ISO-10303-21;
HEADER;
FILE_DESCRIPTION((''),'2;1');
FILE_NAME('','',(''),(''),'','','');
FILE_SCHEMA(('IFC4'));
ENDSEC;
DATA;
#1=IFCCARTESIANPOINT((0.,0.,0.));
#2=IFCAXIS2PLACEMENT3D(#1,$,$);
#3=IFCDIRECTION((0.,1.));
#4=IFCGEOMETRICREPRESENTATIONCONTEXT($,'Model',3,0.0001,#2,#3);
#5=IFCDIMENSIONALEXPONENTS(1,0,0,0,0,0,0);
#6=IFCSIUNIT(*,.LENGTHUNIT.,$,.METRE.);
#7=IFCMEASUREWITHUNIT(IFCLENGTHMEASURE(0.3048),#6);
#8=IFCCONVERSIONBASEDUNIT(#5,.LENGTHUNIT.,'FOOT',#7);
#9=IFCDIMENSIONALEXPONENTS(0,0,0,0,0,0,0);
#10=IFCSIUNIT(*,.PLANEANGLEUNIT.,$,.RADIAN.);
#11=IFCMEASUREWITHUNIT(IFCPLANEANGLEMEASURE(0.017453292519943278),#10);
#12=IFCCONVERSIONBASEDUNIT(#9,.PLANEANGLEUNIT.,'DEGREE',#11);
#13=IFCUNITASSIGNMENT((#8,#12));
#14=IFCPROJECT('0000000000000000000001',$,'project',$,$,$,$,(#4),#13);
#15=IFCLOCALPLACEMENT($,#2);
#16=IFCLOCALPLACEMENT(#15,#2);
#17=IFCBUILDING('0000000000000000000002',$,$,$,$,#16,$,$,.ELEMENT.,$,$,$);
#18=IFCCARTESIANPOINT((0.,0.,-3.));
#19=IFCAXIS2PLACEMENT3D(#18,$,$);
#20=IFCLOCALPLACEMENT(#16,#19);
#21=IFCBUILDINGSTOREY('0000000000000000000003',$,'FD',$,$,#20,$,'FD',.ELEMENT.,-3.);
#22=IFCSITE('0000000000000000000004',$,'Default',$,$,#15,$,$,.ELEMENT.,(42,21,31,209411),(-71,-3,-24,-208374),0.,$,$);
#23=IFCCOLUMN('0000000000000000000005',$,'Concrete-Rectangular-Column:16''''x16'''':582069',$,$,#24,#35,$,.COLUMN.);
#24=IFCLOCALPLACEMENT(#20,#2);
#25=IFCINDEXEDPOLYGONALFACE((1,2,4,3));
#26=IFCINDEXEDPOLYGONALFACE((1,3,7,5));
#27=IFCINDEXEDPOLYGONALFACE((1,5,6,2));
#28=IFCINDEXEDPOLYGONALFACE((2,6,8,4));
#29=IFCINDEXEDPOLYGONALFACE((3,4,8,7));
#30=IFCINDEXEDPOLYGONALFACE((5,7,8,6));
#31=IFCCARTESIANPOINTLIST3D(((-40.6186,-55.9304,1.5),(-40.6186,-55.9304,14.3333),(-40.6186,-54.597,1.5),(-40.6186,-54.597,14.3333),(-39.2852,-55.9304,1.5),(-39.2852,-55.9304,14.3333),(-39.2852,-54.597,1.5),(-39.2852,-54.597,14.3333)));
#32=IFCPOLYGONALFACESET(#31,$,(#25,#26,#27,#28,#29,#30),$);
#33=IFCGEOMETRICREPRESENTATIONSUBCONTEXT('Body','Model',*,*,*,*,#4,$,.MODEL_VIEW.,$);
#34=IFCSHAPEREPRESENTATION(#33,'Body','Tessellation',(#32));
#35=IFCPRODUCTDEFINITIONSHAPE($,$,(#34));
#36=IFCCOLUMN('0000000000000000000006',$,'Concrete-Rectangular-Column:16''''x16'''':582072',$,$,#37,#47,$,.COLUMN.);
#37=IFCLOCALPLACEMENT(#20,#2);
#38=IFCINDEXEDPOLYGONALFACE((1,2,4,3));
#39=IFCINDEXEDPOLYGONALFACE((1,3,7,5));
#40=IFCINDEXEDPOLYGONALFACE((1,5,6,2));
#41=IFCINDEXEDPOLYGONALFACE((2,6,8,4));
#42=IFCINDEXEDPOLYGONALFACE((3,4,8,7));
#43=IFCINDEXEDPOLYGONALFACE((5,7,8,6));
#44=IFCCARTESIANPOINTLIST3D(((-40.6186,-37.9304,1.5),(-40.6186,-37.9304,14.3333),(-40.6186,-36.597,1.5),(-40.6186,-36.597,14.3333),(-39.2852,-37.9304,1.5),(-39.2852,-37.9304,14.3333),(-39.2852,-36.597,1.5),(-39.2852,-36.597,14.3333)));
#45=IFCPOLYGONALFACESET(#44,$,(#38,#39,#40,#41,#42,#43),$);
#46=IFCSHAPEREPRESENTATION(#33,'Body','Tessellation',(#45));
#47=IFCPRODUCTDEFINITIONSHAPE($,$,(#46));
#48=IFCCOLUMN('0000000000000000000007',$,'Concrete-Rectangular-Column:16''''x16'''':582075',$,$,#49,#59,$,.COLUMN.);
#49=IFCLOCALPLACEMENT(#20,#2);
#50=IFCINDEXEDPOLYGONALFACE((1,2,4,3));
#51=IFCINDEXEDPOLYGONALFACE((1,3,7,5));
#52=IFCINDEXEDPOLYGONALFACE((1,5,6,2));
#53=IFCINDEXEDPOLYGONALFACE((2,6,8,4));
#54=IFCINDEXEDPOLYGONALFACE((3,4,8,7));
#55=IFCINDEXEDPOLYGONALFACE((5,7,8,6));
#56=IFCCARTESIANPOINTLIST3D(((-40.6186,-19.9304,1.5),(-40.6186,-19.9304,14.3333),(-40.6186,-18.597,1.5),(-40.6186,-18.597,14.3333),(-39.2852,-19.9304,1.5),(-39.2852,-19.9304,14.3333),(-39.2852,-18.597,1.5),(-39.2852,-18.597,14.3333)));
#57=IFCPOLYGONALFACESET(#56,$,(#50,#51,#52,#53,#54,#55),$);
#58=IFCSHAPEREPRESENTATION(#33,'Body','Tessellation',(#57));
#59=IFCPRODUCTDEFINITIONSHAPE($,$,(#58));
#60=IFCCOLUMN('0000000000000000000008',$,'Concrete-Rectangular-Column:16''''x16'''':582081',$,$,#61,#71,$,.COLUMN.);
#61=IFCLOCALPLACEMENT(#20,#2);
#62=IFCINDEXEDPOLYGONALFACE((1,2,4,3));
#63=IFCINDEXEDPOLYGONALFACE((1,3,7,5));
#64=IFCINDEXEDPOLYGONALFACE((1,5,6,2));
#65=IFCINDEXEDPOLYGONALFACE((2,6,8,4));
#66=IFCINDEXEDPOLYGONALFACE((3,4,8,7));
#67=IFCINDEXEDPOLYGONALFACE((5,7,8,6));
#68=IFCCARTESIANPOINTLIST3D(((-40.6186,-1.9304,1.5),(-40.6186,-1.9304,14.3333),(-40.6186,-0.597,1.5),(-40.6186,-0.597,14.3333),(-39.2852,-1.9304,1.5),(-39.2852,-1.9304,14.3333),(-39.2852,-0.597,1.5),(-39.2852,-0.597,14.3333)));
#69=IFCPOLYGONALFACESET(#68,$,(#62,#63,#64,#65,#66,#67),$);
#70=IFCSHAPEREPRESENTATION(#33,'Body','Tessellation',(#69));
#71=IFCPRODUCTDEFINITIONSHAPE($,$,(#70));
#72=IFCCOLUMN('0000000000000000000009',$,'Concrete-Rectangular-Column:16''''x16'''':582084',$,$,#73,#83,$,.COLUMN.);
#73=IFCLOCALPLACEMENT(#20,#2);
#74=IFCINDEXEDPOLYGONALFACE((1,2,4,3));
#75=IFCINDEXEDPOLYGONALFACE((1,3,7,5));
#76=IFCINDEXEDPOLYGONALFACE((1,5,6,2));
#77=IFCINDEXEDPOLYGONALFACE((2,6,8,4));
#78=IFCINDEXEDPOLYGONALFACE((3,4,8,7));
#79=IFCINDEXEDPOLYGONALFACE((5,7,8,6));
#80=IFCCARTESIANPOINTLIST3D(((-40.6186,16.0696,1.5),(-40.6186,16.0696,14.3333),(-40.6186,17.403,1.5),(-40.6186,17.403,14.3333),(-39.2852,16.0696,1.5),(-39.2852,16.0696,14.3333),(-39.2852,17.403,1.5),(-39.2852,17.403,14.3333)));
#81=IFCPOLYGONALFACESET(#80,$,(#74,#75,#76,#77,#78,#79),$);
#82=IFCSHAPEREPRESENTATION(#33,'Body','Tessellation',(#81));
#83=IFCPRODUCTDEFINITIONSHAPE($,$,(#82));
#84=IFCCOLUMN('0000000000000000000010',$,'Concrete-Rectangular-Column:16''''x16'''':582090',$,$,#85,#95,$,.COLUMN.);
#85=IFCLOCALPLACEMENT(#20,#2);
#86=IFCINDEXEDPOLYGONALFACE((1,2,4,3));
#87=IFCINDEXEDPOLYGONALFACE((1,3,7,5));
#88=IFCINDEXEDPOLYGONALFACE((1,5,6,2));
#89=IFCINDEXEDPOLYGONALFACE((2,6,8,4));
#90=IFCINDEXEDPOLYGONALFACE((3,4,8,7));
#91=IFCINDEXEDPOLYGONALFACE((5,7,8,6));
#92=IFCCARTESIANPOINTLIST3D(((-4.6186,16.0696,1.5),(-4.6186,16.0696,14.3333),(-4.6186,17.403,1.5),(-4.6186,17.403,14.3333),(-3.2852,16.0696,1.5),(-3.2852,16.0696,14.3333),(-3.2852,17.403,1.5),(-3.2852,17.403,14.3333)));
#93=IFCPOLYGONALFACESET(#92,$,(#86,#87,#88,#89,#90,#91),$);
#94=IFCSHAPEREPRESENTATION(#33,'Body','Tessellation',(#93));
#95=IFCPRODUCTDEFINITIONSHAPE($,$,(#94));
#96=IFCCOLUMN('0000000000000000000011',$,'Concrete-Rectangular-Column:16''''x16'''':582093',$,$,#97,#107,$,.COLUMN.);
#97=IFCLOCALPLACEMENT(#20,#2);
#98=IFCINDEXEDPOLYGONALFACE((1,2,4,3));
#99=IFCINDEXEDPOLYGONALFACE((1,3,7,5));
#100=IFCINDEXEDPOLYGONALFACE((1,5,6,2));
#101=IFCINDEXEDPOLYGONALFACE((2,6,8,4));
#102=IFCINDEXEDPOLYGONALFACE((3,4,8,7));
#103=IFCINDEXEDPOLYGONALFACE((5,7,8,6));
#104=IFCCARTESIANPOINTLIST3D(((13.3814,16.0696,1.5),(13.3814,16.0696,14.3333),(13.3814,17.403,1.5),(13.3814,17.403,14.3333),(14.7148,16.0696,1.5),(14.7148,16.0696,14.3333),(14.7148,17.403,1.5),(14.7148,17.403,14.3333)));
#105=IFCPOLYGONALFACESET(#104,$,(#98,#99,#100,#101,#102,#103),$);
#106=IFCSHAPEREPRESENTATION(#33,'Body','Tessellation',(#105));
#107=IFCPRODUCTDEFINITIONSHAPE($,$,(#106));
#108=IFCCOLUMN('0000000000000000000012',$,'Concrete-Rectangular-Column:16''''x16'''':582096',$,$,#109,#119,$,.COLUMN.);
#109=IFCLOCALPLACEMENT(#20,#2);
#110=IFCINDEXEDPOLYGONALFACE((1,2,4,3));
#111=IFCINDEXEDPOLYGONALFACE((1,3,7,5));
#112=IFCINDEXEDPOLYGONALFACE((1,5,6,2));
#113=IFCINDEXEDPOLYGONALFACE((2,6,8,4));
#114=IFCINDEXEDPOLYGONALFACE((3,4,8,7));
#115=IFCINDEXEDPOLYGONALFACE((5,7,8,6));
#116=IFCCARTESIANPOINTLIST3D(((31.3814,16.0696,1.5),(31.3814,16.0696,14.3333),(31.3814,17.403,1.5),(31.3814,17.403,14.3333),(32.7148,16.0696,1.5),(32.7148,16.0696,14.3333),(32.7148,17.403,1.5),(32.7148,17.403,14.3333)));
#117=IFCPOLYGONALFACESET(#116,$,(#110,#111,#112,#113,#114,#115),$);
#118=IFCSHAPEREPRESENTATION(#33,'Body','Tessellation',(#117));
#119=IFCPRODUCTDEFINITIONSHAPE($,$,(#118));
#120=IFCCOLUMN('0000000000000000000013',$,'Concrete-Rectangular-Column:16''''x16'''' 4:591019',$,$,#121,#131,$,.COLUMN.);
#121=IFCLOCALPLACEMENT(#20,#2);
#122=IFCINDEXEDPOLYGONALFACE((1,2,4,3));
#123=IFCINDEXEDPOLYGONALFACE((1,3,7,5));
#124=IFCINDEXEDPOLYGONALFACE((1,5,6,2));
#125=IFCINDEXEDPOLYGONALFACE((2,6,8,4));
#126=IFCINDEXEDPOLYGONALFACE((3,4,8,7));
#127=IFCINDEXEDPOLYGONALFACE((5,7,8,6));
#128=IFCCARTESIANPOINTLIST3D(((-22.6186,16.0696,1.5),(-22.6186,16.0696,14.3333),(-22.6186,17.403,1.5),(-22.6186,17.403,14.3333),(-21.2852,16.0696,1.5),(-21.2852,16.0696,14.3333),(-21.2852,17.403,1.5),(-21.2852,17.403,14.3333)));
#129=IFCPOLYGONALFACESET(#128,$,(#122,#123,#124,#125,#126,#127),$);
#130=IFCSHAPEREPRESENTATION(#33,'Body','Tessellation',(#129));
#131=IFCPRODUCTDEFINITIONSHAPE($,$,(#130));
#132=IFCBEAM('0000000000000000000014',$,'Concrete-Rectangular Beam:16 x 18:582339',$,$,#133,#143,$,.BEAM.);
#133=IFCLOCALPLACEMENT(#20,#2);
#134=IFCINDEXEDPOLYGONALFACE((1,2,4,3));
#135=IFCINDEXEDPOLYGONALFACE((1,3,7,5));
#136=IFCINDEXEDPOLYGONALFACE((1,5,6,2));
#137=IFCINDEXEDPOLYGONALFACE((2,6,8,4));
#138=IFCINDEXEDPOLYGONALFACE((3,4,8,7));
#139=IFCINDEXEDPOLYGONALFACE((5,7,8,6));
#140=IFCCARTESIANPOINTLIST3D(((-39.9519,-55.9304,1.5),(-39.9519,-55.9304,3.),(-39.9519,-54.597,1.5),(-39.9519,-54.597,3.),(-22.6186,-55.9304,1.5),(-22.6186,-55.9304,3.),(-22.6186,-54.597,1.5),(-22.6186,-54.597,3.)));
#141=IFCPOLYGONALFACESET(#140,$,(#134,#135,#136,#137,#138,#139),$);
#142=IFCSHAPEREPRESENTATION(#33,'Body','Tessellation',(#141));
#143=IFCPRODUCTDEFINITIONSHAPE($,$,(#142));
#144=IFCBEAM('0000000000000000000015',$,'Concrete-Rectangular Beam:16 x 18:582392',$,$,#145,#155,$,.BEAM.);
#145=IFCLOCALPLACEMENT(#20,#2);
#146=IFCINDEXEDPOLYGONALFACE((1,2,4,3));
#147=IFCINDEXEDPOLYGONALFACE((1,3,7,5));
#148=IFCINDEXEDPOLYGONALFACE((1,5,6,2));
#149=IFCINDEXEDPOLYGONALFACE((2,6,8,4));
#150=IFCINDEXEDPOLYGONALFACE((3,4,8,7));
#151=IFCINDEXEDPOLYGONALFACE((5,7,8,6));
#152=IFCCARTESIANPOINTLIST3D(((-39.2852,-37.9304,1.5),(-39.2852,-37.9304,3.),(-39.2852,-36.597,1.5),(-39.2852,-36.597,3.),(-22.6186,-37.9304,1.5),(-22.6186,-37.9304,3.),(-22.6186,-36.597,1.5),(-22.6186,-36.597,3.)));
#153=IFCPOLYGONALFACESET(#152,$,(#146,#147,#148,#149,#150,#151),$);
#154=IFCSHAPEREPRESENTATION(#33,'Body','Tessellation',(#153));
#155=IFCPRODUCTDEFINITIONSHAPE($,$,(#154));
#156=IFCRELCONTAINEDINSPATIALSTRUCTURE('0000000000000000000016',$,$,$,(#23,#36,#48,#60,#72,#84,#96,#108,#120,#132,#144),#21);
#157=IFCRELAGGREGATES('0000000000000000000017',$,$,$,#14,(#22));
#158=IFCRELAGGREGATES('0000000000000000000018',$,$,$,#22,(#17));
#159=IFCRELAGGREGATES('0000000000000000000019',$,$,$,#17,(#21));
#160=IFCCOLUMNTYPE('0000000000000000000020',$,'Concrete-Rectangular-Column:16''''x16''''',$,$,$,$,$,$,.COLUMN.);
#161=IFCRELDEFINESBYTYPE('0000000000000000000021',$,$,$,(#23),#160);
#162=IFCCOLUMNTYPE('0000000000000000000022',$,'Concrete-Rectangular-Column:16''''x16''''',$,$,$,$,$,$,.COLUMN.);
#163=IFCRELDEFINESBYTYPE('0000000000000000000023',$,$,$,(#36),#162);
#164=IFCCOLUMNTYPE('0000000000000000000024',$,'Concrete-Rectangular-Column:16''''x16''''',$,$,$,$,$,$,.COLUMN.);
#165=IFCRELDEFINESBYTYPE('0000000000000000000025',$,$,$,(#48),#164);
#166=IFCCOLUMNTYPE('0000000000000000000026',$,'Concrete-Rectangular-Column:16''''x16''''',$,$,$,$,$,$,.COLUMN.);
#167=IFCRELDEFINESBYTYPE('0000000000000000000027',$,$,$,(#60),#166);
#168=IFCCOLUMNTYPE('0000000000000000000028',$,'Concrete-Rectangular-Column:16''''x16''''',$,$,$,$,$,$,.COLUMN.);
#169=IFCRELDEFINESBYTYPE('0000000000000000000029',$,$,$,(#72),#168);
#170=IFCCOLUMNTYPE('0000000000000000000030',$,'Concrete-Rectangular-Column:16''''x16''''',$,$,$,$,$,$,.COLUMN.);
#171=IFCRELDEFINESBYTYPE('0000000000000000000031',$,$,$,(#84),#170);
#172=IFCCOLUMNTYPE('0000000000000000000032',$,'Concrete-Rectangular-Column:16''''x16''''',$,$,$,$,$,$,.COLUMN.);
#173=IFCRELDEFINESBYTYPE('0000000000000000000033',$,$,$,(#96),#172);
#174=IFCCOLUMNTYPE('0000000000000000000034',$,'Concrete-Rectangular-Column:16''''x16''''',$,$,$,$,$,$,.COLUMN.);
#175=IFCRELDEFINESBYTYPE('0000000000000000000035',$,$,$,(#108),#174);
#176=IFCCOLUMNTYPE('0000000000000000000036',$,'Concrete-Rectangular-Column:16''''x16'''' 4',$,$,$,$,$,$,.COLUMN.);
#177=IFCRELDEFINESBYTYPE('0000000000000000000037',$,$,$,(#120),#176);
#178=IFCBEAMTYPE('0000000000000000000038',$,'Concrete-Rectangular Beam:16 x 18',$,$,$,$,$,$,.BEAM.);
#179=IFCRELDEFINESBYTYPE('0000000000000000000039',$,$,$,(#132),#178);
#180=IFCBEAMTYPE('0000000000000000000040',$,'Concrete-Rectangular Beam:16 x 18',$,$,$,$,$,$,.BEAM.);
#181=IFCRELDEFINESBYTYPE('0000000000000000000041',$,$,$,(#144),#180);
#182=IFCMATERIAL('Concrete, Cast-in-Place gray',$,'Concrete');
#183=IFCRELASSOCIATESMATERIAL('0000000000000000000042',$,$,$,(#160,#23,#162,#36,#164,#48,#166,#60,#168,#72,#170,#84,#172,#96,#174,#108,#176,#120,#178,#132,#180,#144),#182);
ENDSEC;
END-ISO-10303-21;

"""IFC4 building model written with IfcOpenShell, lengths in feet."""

from ifc_helpers import new_model, entity, si_unit, converted_unit, direction, frame, origin, place, context, subcontext, project, spatial, indexed_curve, outline, extrude, source, transform, mapped, material, type_object, type_shapes, element, save


model = new_model("IFC4")

# Units and contexts
model_context = context("Model", 3, precision=0.0001, world=origin(), true_north=direction((0.0, 1.0)))
body_context = subcontext(model_context, "Body", "Model", "MODEL_VIEW")
ifc_project = project(units=[converted_unit("LENGTHUNIT", "FOOT", entity("IfcLengthMeasure", 0.3048), si_unit("LENGTHUNIT", "METRE"), dimensions=[1, 0, 0, 0, 0, 0, 0]), converted_unit("PLANEANGLEUNIT", "DEGREE", entity("IfcPlaneAngleMeasure", 0.017453292519943278), si_unit("PLANEANGLEUNIT", "RADIAN"), dimensions=[0, 0, 0, 0, 0, 0, 0])], contexts=[model_context])

# Site, building, storey
site_placement = place(None, origin())
site = spatial("IfcSite", under=ifc_project, at=site_placement, Name="Default", CompositionType="ELEMENT", RefLatitude=(42, 21, 31, 209411), RefLongitude=(-71, -3, -24, -208374), RefElevation=0.0)
building_placement = place(site_placement, origin())
building = spatial("IfcBuilding", under=site, at=building_placement, CompositionType="ELEMENT")
storey_placement = place(building_placement, frame((0.0, 0.0, -3.0)))
storey = spatial("IfcBuildingStorey", under=building, at=storey_placement, Name="FD", LongName="FD", CompositionType="ELEMENT", Elevation=-3.0)

# Columns
ifc_material = material(Name="Concrete, Cast-in-Place gray", Category="Concrete")
column_type_1 = type_object("IfcColumnType", Name="Concrete-Rectangular-Column:16''x16''", PredefinedType="COLUMN", material=ifc_material)
shared_shape_1 = source(origin(), body_context, "Body", "SweptSolid", [
    extrude(outline(indexed_curve([(-0.6667, -0.6667), (0.6667, -0.6667), (0.6667, 0.6667), (-0.6667, 0.6667), (-0.6667, -0.6667)], self_intersect=False)), frame((-39.9519, -55.2637, -1.5), z_axis=(0.0, 0.0, 1.0), x_axis=(-1.0, 0.0, 0.0)), (0.0, 0.0, 1.0), 12.8333),
])
type_shapes(column_type_1, [shared_shape_1])
column_1_placement = place(storey_placement, frame((0.0, 0.0, 3.0)))
element("IfcColumn", 1, at=column_1_placement, inside=storey, type_object=column_type_1, material=ifc_material, Name="Concrete-Rectangular-Column:16''x16'':582069", PredefinedType="COLUMN", context=body_context, shape_type="MappedRepresentation", body=[
    mapped(shared_shape_1, transform((0.0, 0.0, 0.0), scale=1.0)),
])
column_type_2 = type_object("IfcColumnType", Name="Concrete-Rectangular-Column:16''x16''", PredefinedType="COLUMN", material=ifc_material)
shared_shape_2 = source(origin(), body_context, "Body", "SweptSolid", [
    extrude(outline(indexed_curve([(-0.6667, -0.6667), (0.6667, -0.6667), (0.6667, 0.6667), (-0.6667, 0.6667), (-0.6667, -0.6667)], self_intersect=False)), frame((-39.9519, -37.2637, -1.5), z_axis=(0.0, 0.0, 1.0), x_axis=(-1.0, 0.0, 0.0)), (0.0, 0.0, 1.0), 12.8333),
])
type_shapes(column_type_2, [shared_shape_2])
column_2_placement = place(storey_placement, frame((0.0, 0.0, 3.0)))
element("IfcColumn", 2, at=column_2_placement, inside=storey, type_object=column_type_2, material=ifc_material, Name="Concrete-Rectangular-Column:16''x16'':582072", PredefinedType="COLUMN", context=body_context, shape_type="MappedRepresentation", body=[
    mapped(shared_shape_2, transform((0.0, 0.0, 0.0), scale=1.0)),
])
column_type_3 = type_object("IfcColumnType", Name="Concrete-Rectangular-Column:16''x16''", PredefinedType="COLUMN", material=ifc_material)
shared_shape_3 = source(origin(), body_context, "Body", "SweptSolid", [
    extrude(outline(indexed_curve([(-0.6667, -0.6667), (0.6667, -0.6667), (0.6667, 0.6667), (-0.6667, 0.6667), (-0.6667, -0.6667)], self_intersect=False)), frame((-39.9519, -19.2637, -1.5), z_axis=(0.0, 0.0, 1.0), x_axis=(-1.0, 0.0, 0.0)), (0.0, 0.0, 1.0), 12.8333),
])
type_shapes(column_type_3, [shared_shape_3])
column_3_placement = place(storey_placement, frame((0.0, 0.0, 3.0)))
element("IfcColumn", 3, at=column_3_placement, inside=storey, type_object=column_type_3, material=ifc_material, Name="Concrete-Rectangular-Column:16''x16'':582075", PredefinedType="COLUMN", context=body_context, shape_type="MappedRepresentation", body=[
    mapped(shared_shape_3, transform((0.0, 0.0, 0.0), scale=1.0)),
])
column_type_4 = type_object("IfcColumnType", Name="Concrete-Rectangular-Column:16''x16''", PredefinedType="COLUMN", material=ifc_material)
shared_shape_4 = source(origin(), body_context, "Body", "SweptSolid", [
    extrude(outline(indexed_curve([(-0.6667, -0.6667), (0.6667, -0.6667), (0.6667, 0.6667), (-0.6667, 0.6667), (-0.6667, -0.6667)], self_intersect=False)), frame((-39.9519, -1.2637, -1.5), z_axis=(0.0, 0.0, 1.0), x_axis=(-1.0, 0.0, 0.0)), (0.0, 0.0, 1.0), 12.8333),
])
type_shapes(column_type_4, [shared_shape_4])
column_4_placement = place(storey_placement, frame((0.0, 0.0, 3.0)))
element("IfcColumn", 4, at=column_4_placement, inside=storey, type_object=column_type_4, material=ifc_material, Name="Concrete-Rectangular-Column:16''x16'':582081", PredefinedType="COLUMN", context=body_context, shape_type="MappedRepresentation", body=[
    mapped(shared_shape_4, transform((0.0, 0.0, 0.0), scale=1.0)),
])
column_type_5 = type_object("IfcColumnType", Name="Concrete-Rectangular-Column:16''x16''", PredefinedType="COLUMN", material=ifc_material)
shared_shape_5 = source(origin(), body_context, "Body", "SweptSolid", [
    extrude(outline(indexed_curve([(-0.6667, -0.6667), (0.6667, -0.6667), (0.6667, 0.6667), (-0.6667, 0.6667), (-0.6667, -0.6667)], self_intersect=False)), frame((-39.9519, 16.7363, -1.5), z_axis=(0.0, 0.0, 1.0), x_axis=(-1.0, 0.0, 0.0)), (0.0, 0.0, 1.0), 12.8333),
])
type_shapes(column_type_5, [shared_shape_5])
column_5_placement = place(storey_placement, frame((0.0, 0.0, 3.0)))
element("IfcColumn", 5, at=column_5_placement, inside=storey, type_object=column_type_5, material=ifc_material, Name="Concrete-Rectangular-Column:16''x16'':582084", PredefinedType="COLUMN", context=body_context, shape_type="MappedRepresentation", body=[
    mapped(shared_shape_5, transform((0.0, 0.0, 0.0), scale=1.0)),
])
column_type_6 = type_object("IfcColumnType", Name="Concrete-Rectangular-Column:16''x16''", PredefinedType="COLUMN", material=ifc_material)
shared_shape_6 = source(origin(), body_context, "Body", "SweptSolid", [
    extrude(outline(indexed_curve([(-0.6667, -0.6667), (0.6667, -0.6667), (0.6667, 0.6667), (-0.6667, 0.6667), (-0.6667, -0.6667)], self_intersect=False)), frame((-3.9519, 16.7363, -1.5), z_axis=(0.0, 0.0, 1.0), x_axis=(-1.0, 0.0, 0.0)), (0.0, 0.0, 1.0), 12.8333),
])
type_shapes(column_type_6, [shared_shape_6])
column_6_placement = place(storey_placement, frame((0.0, 0.0, 3.0)))
element("IfcColumn", 6, at=column_6_placement, inside=storey, type_object=column_type_6, material=ifc_material, Name="Concrete-Rectangular-Column:16''x16'':582090", PredefinedType="COLUMN", context=body_context, shape_type="MappedRepresentation", body=[
    mapped(shared_shape_6, transform((0.0, 0.0, 0.0), scale=1.0)),
])
column_type_7 = type_object("IfcColumnType", Name="Concrete-Rectangular-Column:16''x16''", PredefinedType="COLUMN", material=ifc_material)
shared_shape_7 = source(origin(), body_context, "Body", "SweptSolid", [
    extrude(outline(indexed_curve([(-0.6667, -0.6667), (0.6667, -0.6667), (0.6667, 0.6667), (-0.6667, 0.6667), (-0.6667, -0.6667)], self_intersect=False)), frame((14.0481, 16.7363, -1.5), z_axis=(0.0, 0.0, 1.0), x_axis=(-1.0, 0.0, 0.0)), (0.0, 0.0, 1.0), 12.8333),
])
type_shapes(column_type_7, [shared_shape_7])
column_7_placement = place(storey_placement, frame((0.0, 0.0, 3.0)))
element("IfcColumn", 7, at=column_7_placement, inside=storey, type_object=column_type_7, material=ifc_material, Name="Concrete-Rectangular-Column:16''x16'':582093", PredefinedType="COLUMN", context=body_context, shape_type="MappedRepresentation", body=[
    mapped(shared_shape_7, transform((0.0, 0.0, 0.0), scale=1.0)),
])
column_type_8 = type_object("IfcColumnType", Name="Concrete-Rectangular-Column:16''x16''", PredefinedType="COLUMN", material=ifc_material)
shared_shape_8 = source(origin(), body_context, "Body", "SweptSolid", [
    extrude(outline(indexed_curve([(-0.6667, -0.6667), (0.6667, -0.6667), (0.6667, 0.6667), (-0.6667, 0.6667), (-0.6667, -0.6667)], self_intersect=False)), frame((32.0481, 16.7363, -1.5), z_axis=(0.0, 0.0, 1.0), x_axis=(-1.0, 0.0, 0.0)), (0.0, 0.0, 1.0), 12.8333),
])
type_shapes(column_type_8, [shared_shape_8])
column_8_placement = place(storey_placement, frame((0.0, 0.0, 3.0)))
element("IfcColumn", 8, at=column_8_placement, inside=storey, type_object=column_type_8, material=ifc_material, Name="Concrete-Rectangular-Column:16''x16'':582096", PredefinedType="COLUMN", context=body_context, shape_type="MappedRepresentation", body=[
    mapped(shared_shape_8, transform((0.0, 0.0, 0.0), scale=1.0)),
])
column_type_9 = type_object("IfcColumnType", Name="Concrete-Rectangular-Column:16''x16'' 4", PredefinedType="COLUMN", material=ifc_material)
shared_shape_9 = source(origin(), body_context, "Body", "SweptSolid", [
    extrude(outline(indexed_curve([(-0.6667, -0.6667), (0.6667, -0.6667), (0.6667, 0.6667), (-0.6667, 0.6667), (-0.6667, -0.6667)], self_intersect=False)), frame((-21.9519, 16.7363, -1.5), z_axis=(0.0, 0.0, 1.0), x_axis=(-1.0, 0.0, 0.0)), (0.0, 0.0, 1.0), 12.8333),
])
type_shapes(column_type_9, [shared_shape_9])
column_9_placement = place(storey_placement, frame((0.0, 0.0, 3.0)))
element("IfcColumn", 9, at=column_9_placement, inside=storey, type_object=column_type_9, material=ifc_material, Name="Concrete-Rectangular-Column:16''x16'' 4:591019", PredefinedType="COLUMN", context=body_context, shape_type="MappedRepresentation", body=[
    mapped(shared_shape_9, transform((0.0, 0.0, 0.0), scale=1.0)),
])

# Beams
beam_type_1 = type_object("IfcBeamType", Name="Concrete-Rectangular Beam:16 x 18", PredefinedType="BEAM", material=ifc_material)
shared_shape_10 = source(origin(), body_context, "Body", "SweptSolid", [
    extrude(outline(indexed_curve([(-0.75, -0.6667), (0.75, -0.6667), (0.75, 0.6667), (-0.75, 0.6667), (-0.75, -0.6667)], self_intersect=False)), frame((-39.9519, -55.2637, -0.75), z_axis=(1.0, 0.0, 0.0), x_axis=(0.0, 0.0, -1.0)), (0.0, 0.0, 1.0), 17.3333),
])
type_shapes(beam_type_1, [shared_shape_10])
beam_1_placement = place(storey_placement, frame((0.0, 0.0, 3.0)))
element("IfcBeam", 10, at=beam_1_placement, inside=storey, type_object=beam_type_1, material=ifc_material, Name="Concrete-Rectangular Beam:16 x 18:582339", PredefinedType="BEAM", context=body_context, shape_type="MappedRepresentation", body=[
    mapped(shared_shape_10, transform((0.0, 0.0, 0.0), scale=1.0)),
])
beam_type_2 = type_object("IfcBeamType", Name="Concrete-Rectangular Beam:16 x 18", PredefinedType="BEAM", material=ifc_material)
shared_shape_11 = source(origin(), body_context, "Body", "SweptSolid", [
    extrude(outline(indexed_curve([(-0.75, -0.6667), (0.75, -0.6667), (0.75, 0.6667), (-0.75, 0.6667), (-0.75, -0.6667)], self_intersect=False)), frame((-39.2852, -37.2637, -0.75), z_axis=(1.0, 0.0, 0.0), x_axis=(0.0, 0.0, -1.0)), (0.0, 0.0, 1.0), 16.6667),
])
type_shapes(beam_type_2, [shared_shape_11])
beam_2_placement = place(storey_placement, frame((0.0, 0.0, 3.0)))
element("IfcBeam", 11, at=beam_2_placement, inside=storey, type_object=beam_type_2, material=ifc_material, Name="Concrete-Rectangular Beam:16 x 18:582392", PredefinedType="BEAM", context=body_context, shape_type="MappedRepresentation", body=[
    mapped(shared_shape_11, transform((0.0, 0.0, 0.0), scale=1.0)),
])

save(model, "model.ifc")
